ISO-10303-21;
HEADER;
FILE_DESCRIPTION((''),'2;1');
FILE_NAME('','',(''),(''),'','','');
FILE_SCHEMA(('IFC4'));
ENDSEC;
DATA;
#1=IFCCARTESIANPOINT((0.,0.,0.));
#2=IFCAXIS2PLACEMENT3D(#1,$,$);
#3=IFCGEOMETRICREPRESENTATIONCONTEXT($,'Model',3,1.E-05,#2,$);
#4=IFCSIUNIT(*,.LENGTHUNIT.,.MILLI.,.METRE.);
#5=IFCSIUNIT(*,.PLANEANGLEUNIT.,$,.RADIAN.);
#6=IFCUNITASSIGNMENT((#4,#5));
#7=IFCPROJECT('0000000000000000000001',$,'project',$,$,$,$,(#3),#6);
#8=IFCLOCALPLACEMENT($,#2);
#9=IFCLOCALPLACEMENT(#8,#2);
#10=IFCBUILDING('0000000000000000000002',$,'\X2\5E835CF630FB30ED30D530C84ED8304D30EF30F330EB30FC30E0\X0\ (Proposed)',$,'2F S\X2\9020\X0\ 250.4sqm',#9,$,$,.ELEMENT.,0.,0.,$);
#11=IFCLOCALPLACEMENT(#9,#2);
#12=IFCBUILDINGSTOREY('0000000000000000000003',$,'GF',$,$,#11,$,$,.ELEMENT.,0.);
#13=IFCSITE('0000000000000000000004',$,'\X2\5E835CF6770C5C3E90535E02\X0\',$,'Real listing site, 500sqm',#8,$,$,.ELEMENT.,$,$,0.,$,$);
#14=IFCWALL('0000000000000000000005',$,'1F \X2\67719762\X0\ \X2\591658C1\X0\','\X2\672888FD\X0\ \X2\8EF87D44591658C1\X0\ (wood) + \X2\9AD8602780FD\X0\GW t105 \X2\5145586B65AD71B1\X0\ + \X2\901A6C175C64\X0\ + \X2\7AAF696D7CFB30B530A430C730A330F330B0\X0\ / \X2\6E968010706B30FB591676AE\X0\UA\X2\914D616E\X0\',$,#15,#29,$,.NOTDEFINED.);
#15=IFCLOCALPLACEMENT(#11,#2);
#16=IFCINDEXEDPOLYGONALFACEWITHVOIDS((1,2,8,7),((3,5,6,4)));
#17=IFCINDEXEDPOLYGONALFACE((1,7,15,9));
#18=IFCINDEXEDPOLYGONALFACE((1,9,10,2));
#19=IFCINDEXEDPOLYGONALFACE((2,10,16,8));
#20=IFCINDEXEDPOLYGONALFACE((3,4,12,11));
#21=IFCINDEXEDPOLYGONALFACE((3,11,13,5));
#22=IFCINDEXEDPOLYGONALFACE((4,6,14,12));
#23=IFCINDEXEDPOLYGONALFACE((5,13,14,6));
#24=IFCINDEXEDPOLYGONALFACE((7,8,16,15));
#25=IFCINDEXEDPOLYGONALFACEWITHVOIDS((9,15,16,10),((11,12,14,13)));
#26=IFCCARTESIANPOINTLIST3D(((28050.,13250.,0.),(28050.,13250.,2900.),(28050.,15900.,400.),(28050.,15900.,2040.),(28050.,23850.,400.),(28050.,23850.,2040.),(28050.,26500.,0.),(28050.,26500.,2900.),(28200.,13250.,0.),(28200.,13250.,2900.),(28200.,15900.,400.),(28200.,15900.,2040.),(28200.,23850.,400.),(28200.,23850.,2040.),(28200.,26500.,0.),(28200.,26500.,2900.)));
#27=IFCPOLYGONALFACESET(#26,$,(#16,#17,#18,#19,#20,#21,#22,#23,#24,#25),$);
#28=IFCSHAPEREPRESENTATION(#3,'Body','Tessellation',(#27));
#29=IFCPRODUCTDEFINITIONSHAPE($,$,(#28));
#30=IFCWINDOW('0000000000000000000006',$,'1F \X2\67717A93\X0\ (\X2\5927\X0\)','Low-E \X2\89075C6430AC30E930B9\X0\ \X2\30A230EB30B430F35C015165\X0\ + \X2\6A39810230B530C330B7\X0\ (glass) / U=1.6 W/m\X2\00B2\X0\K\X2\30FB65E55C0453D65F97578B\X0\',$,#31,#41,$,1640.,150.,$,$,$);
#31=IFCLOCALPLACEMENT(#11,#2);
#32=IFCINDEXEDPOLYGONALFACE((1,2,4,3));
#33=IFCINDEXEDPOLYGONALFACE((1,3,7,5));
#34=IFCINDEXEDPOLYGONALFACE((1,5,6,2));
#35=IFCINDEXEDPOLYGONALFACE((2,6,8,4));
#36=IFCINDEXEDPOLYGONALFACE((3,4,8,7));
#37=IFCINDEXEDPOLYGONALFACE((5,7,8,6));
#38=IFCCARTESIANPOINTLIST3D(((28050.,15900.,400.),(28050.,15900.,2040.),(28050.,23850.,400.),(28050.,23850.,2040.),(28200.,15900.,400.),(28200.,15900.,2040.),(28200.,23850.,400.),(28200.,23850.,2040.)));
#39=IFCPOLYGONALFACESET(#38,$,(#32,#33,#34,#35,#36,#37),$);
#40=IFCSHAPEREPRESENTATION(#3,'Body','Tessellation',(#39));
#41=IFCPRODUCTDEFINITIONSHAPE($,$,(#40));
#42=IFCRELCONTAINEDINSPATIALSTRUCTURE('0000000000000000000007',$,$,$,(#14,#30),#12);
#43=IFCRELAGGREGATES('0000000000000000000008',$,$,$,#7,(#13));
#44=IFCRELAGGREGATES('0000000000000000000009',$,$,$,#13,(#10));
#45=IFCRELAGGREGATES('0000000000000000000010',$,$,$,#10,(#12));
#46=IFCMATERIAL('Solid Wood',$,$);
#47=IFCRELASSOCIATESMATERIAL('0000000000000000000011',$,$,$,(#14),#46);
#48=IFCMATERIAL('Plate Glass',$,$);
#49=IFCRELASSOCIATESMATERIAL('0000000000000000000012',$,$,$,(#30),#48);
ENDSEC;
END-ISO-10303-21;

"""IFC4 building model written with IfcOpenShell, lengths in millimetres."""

from ifc_helpers import new_model, si_unit, frame, frame_2d, origin, place, context, project, spatial, rectangle, extrude, material, element, fill, save


model = new_model("IFC4")

# Units and contexts
model_context = context("Model", 3, precision=1e-05, world=origin())
ifc_project = project(units=[si_unit("LENGTHUNIT", "METRE", prefix="MILLI"), si_unit("PLANEANGLEUNIT", "RADIAN")], contexts=[model_context])

# Site, building, storey
site_placement = place(None, origin())
site = spatial("IfcSite", under=ifc_project, at=site_placement, Name="広島県尾道市", ObjectType="Real listing site, 500sqm", CompositionType="ELEMENT", RefElevation=0.0)
building_placement = place(site_placement, origin())
building = spatial("IfcBuilding", under=site, at=building_placement, Name="広島・ロフト付きワンルーム (Proposed)", ObjectType="2F S造 250.4sqm", CompositionType="ELEMENT", ElevationOfRefHeight=0.0, ElevationOfTerrain=0.0)
storey_placement = place(building_placement, origin())
storey = spatial("IfcBuildingStorey", under=building, at=storey_placement, Name="GF", CompositionType="ELEMENT", Elevation=0.0)

# Shared definitions
ifc_material_1 = material(Name="Solid Wood")

# Wall, opening, window
wall_1_placement = place(storey_placement, frame((14025.0, 6625.0, 0.0)))
wall_1 = element("IfcWall", 1, at=wall_1_placement, inside=storey, material=ifc_material_1, Name="1F 東面 外壁", Description="木製 軸組外壁 (wood) + 高性能GW t105 充填断熱 + 通気層 + 窯業系サイディング / 準耐火・外皮UA配慮", PredefinedType="NOTDEFINED", context=model_context, shape_type="SweptSolid", body=[
    extrude(rectangle(XDim=150.0, YDim=13250.0, at=frame_2d((75.0, 6625.0))), frame((14025.0, 6625.0, 0.0)), (0.0, 0.0, 1.0), 2900.0),
])
opening_1_placement = place(storey_placement, frame((14025.0, 7950.0, 200.0)))
opening_1 = element("IfcOpeningElement", 2, at=opening_1_placement, cuts=wall_1, PredefinedType="NOTDEFINED", context=model_context, shape_type="SweptSolid", body=[
    extrude(rectangle(XDim=150.0, YDim=7950.0, at=frame_2d((75.0, 3975.0))), frame((14025.0, 7950.0, 200.0)), (0.0, 0.0, 1.0), 1640.0),
])
ifc_material_2 = material(Name="Plate Glass")
window_1_placement = place(storey_placement, frame((14025.0, 7950.0, 200.0)))
window_1 = element("IfcWindow", 3, at=window_1_placement, inside=storey, material=ifc_material_2, Name="1F 東窓 (大)", Description="Low-E 複層ガラス アルゴン封入 + 樹脂サッシ (glass) / U=1.6 W/m²K・日射取得型", OverallHeight=1640.0, OverallWidth=150.0, context=model_context, shape_type="SweptSolid", body=[
    extrude(rectangle(XDim=150.0, YDim=7950.0, at=frame_2d((75.0, 3975.0))), frame((14025.0, 7950.0, 200.0)), (0.0, 0.0, 1.0), 1640.0),
])
fill(opening_1, window_1)

save(model, "model.ifc")
